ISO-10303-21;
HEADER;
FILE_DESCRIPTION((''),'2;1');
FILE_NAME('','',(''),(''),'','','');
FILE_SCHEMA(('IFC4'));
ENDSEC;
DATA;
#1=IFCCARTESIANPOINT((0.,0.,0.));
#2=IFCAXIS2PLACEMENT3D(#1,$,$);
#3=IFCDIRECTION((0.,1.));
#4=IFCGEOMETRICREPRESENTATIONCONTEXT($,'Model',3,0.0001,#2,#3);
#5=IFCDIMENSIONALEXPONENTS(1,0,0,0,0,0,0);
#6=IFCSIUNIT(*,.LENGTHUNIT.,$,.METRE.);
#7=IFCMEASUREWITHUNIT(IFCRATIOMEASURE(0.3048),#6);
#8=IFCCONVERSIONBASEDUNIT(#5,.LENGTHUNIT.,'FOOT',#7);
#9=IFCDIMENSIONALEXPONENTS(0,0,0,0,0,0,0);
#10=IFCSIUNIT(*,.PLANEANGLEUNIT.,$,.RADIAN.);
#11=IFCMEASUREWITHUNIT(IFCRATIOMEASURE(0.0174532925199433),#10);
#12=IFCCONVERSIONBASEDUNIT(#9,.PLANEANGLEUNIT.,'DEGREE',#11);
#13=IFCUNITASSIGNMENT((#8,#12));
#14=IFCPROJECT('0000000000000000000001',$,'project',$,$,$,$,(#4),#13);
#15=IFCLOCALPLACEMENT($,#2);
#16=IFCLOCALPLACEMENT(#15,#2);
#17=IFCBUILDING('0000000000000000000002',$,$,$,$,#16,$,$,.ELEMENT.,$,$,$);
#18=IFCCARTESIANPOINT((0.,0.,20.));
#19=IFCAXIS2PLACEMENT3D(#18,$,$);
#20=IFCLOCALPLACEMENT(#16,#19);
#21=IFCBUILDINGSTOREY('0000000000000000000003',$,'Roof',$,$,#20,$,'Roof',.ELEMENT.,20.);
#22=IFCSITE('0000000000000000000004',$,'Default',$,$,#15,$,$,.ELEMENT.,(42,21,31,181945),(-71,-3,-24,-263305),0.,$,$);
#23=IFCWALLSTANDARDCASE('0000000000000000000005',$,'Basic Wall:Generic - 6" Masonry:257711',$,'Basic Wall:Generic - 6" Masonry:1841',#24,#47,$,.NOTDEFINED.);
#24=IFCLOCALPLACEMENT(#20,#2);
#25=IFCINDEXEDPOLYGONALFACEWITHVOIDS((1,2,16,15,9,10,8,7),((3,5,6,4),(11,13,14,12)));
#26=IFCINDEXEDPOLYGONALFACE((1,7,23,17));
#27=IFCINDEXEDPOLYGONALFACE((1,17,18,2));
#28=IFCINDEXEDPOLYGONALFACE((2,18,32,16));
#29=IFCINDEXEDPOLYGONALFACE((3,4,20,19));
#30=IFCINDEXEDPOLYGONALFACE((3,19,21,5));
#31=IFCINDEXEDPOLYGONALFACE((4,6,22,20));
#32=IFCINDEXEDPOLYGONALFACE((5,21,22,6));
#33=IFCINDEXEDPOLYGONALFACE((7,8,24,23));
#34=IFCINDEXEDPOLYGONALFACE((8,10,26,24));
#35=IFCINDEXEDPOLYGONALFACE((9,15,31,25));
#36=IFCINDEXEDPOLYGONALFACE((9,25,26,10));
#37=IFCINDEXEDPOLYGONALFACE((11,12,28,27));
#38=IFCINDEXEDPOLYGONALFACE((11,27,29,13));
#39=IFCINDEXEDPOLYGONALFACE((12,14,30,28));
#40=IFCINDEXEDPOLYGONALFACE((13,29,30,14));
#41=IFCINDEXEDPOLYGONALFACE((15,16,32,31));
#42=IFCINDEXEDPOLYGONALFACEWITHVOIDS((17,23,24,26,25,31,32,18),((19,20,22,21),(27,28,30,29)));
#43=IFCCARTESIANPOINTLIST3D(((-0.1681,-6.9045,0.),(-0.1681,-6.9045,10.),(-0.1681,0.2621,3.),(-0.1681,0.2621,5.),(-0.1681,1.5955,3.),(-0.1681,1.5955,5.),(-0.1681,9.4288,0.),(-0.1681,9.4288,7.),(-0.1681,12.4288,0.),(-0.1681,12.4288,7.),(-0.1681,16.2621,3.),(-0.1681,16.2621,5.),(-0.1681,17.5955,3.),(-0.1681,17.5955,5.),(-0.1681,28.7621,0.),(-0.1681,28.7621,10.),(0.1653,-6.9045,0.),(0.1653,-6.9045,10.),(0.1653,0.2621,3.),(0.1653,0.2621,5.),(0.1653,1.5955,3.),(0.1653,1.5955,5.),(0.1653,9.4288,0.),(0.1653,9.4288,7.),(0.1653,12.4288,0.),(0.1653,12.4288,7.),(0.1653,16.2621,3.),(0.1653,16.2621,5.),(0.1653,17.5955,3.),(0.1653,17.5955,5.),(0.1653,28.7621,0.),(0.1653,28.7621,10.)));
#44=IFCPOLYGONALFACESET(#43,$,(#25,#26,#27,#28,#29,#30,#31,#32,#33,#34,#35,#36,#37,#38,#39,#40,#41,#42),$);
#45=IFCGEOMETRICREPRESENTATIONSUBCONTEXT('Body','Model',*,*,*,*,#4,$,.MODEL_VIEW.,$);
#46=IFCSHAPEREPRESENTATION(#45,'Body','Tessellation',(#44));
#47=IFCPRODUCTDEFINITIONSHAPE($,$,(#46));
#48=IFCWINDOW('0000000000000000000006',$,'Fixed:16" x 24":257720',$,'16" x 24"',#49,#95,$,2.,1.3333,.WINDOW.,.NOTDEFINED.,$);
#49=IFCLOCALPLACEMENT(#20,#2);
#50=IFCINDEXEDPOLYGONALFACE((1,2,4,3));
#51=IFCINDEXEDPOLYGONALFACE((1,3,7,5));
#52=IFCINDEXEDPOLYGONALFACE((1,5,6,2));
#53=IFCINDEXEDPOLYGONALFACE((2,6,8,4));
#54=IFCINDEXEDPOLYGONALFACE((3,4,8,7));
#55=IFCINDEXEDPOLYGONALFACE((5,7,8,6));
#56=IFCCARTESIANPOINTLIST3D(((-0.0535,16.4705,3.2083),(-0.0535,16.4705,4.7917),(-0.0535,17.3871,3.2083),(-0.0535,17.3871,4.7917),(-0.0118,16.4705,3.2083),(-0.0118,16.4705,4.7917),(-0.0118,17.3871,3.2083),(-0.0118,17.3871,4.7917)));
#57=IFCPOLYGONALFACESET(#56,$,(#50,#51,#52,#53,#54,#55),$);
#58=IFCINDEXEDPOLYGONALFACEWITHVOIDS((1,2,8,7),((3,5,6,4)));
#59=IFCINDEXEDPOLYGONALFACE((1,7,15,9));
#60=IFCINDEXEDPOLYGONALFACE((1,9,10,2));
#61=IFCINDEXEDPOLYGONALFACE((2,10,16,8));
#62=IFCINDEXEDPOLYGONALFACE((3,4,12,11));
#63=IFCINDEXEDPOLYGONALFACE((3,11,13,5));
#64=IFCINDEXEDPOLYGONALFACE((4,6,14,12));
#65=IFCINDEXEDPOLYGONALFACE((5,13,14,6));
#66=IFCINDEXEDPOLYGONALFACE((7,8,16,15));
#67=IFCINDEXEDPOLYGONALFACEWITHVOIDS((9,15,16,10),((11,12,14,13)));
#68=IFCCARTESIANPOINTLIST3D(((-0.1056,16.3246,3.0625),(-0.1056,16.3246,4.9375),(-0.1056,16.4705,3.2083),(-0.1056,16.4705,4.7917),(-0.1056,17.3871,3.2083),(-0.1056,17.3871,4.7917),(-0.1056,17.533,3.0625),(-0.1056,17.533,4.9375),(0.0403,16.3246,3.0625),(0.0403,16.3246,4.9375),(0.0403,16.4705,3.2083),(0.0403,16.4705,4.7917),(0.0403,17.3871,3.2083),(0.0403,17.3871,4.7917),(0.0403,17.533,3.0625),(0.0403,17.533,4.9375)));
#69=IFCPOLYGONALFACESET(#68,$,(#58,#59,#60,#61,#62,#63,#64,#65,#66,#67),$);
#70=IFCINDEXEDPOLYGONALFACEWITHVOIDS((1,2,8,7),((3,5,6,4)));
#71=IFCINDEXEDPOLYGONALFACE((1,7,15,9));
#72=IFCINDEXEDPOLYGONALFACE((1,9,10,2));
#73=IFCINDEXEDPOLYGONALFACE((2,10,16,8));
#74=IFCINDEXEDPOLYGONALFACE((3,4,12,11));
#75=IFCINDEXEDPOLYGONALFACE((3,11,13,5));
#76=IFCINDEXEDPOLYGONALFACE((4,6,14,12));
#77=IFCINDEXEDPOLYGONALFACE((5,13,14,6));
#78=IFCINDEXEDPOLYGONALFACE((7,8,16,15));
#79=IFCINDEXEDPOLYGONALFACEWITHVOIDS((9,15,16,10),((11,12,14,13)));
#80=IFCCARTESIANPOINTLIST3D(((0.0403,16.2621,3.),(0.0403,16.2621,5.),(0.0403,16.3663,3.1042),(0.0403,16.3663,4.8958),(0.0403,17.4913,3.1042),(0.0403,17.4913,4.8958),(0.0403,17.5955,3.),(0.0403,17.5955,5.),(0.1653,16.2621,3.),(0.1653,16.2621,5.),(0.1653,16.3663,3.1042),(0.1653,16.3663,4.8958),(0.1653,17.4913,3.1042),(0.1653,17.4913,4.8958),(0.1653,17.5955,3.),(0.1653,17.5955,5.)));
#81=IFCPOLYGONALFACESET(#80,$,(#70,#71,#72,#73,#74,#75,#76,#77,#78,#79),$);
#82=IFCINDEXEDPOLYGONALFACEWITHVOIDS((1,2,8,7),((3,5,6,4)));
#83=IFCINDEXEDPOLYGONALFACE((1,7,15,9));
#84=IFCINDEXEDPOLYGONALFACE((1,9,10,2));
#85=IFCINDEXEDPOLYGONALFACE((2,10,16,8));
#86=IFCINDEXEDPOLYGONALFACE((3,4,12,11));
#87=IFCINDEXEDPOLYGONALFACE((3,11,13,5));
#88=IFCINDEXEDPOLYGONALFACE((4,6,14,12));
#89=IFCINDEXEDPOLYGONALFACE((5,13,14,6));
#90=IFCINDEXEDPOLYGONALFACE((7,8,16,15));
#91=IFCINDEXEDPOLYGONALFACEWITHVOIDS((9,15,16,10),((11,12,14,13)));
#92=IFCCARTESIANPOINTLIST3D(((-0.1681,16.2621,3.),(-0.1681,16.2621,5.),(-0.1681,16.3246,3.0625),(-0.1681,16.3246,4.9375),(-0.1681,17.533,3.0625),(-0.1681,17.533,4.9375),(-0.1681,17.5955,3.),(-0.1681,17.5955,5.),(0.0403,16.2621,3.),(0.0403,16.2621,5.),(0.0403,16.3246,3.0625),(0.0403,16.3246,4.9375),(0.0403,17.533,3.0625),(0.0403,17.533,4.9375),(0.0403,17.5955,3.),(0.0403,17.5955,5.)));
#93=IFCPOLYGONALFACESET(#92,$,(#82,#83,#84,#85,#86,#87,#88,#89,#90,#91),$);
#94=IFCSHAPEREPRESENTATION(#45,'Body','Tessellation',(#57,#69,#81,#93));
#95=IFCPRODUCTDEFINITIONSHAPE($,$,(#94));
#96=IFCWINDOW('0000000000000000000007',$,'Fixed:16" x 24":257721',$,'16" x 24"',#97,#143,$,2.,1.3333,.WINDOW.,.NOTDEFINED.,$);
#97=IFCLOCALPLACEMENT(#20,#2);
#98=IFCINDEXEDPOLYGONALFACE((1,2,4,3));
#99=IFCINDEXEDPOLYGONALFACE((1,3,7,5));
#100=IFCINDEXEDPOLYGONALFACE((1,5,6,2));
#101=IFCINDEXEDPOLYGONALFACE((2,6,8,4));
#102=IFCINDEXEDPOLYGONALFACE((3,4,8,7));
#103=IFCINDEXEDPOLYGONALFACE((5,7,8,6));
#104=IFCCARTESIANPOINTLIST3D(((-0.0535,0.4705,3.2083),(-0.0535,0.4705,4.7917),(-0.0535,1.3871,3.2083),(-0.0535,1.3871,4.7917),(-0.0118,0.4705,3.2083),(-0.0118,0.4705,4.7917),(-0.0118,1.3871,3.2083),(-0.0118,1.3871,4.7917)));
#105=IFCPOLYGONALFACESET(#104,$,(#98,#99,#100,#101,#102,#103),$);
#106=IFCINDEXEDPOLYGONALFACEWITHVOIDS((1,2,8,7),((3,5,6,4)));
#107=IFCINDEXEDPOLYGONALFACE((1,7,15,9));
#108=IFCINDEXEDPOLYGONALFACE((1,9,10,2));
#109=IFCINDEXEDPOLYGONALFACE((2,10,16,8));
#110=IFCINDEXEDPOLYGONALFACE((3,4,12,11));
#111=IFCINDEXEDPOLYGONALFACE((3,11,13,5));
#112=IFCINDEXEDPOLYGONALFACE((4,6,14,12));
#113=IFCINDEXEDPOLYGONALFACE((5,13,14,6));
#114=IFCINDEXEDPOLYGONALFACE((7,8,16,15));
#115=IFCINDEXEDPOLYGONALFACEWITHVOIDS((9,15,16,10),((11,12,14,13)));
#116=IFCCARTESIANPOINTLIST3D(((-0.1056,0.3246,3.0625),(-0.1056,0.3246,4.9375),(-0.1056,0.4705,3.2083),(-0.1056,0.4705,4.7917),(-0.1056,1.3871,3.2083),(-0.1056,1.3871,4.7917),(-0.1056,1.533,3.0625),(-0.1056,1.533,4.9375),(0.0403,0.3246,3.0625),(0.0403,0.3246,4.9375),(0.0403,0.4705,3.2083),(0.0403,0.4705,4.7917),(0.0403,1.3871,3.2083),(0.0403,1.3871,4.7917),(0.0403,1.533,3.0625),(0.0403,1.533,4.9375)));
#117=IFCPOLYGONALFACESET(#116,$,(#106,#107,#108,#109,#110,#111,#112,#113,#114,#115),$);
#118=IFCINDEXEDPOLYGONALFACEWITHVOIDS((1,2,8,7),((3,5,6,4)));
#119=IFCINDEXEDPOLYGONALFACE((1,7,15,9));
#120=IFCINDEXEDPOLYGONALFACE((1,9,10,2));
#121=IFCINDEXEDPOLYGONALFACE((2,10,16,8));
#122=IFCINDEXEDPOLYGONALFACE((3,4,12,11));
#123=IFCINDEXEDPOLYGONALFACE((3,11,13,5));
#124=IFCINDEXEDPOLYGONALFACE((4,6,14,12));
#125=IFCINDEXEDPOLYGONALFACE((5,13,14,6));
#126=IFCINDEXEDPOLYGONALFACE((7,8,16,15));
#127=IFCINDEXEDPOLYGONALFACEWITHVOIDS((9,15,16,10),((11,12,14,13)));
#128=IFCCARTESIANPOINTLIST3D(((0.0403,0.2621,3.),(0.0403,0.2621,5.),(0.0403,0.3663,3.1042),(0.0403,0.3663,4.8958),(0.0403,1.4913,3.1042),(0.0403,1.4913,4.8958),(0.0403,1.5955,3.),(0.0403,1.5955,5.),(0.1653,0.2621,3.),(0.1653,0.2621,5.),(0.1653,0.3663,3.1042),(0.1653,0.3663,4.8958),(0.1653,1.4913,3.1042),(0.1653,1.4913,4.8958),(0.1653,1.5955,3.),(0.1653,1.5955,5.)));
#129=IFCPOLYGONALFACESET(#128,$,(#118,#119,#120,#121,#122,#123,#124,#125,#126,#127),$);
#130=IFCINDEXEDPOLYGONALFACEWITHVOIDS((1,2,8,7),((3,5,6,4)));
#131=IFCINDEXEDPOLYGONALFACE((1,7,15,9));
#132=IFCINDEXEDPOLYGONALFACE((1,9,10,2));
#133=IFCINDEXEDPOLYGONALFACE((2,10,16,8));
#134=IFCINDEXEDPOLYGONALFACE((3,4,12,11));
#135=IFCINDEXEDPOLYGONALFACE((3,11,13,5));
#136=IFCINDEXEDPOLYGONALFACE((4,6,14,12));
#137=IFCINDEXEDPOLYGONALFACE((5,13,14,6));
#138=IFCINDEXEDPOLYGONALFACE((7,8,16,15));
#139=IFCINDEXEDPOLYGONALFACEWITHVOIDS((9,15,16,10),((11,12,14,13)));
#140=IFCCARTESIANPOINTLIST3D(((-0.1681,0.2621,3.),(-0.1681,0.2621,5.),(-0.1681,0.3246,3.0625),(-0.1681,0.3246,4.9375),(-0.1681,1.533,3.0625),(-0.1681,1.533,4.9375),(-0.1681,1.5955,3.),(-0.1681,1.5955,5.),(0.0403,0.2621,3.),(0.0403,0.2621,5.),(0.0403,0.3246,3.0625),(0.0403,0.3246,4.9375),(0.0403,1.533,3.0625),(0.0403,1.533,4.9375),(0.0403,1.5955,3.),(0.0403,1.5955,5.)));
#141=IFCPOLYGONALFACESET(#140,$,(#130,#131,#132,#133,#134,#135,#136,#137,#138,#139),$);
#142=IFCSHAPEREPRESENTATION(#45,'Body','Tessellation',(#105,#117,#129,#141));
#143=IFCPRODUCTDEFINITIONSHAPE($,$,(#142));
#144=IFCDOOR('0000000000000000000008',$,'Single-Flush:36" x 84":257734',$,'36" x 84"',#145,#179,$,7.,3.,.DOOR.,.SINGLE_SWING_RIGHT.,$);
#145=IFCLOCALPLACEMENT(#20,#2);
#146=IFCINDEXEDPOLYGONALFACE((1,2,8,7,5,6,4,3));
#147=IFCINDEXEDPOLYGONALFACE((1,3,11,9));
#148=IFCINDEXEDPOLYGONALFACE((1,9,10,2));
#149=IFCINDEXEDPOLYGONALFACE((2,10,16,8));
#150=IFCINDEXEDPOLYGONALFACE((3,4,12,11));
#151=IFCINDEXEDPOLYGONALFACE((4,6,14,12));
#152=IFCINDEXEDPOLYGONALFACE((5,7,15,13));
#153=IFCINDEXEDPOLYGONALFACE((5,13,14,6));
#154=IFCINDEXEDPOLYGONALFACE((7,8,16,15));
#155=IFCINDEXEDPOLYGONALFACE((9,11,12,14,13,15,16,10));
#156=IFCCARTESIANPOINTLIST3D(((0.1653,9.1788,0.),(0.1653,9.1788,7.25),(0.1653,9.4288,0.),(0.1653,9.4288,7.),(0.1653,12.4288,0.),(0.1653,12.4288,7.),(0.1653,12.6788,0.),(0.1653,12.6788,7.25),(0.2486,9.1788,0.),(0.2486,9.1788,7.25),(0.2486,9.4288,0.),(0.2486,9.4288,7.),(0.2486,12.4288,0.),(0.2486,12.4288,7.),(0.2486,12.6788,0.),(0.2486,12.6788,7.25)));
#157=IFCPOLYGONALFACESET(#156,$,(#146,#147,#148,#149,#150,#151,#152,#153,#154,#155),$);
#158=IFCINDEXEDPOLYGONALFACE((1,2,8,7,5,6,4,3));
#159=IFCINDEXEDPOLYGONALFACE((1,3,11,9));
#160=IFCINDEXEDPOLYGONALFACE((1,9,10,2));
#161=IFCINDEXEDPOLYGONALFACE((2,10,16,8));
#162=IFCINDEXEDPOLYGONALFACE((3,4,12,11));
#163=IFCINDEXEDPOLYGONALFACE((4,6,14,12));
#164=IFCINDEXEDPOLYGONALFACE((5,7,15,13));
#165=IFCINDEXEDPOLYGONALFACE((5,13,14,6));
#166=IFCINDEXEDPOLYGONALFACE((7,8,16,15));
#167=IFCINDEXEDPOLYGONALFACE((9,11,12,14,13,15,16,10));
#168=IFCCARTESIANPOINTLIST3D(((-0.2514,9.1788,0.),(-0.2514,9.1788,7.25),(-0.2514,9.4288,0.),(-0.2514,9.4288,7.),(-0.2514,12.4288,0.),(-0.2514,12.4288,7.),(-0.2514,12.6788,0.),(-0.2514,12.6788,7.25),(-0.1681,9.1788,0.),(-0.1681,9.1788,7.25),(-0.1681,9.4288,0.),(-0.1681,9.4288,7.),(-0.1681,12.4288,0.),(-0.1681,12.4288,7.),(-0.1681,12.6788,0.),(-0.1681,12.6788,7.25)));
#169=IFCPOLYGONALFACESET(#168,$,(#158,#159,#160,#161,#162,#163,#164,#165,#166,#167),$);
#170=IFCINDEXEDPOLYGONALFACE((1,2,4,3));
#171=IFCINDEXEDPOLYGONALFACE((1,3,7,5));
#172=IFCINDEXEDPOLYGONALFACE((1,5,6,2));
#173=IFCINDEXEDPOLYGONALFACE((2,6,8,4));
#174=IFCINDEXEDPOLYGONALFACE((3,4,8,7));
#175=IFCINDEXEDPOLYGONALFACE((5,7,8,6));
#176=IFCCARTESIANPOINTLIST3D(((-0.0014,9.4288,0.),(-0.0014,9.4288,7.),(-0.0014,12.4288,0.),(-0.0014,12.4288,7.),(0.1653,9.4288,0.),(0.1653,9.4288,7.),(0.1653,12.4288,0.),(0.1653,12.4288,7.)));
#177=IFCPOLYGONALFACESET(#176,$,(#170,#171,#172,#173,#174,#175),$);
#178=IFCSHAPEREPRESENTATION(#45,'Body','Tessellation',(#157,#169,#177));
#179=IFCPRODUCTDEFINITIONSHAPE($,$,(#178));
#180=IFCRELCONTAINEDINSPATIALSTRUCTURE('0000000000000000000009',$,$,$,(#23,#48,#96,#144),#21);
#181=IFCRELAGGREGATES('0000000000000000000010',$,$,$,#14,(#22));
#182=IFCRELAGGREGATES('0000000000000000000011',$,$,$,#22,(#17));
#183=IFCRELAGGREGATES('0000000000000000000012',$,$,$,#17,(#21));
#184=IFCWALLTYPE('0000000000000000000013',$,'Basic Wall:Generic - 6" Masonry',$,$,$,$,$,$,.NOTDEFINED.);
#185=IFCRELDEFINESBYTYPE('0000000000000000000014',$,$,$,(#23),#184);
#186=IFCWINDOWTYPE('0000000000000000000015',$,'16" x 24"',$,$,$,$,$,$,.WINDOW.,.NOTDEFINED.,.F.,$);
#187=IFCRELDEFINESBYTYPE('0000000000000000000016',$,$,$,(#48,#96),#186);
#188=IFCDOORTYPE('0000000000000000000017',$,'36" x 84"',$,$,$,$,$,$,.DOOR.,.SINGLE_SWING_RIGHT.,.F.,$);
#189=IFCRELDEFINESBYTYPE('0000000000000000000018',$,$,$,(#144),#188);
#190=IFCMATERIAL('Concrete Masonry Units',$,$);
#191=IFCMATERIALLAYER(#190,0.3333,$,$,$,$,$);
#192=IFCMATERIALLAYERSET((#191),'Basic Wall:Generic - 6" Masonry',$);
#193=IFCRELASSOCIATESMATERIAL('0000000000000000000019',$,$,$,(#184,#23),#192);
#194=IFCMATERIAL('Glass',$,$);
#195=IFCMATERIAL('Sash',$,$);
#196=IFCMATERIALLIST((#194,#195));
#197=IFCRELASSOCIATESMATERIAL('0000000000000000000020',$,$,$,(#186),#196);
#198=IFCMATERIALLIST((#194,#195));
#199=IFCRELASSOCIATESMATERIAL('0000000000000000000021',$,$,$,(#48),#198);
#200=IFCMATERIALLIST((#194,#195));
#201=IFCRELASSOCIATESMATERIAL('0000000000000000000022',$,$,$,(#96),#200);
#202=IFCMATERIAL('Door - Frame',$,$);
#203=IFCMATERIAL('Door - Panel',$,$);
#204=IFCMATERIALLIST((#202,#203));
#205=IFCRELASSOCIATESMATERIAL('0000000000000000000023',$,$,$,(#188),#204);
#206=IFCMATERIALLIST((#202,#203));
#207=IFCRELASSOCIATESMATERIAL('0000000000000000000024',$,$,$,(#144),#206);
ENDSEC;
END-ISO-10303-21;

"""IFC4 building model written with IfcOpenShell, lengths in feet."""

from ifc_helpers import new_model, entity, si_unit, converted_unit, direction, frame, frame_2d, origin, origin_2d_with_axis, place, context, subcontext, project, spatial, polyline, rectangle, outline, extrude, source, transform, mapped, material, material_list, layer, layer_set, layer_usage, type_object, type_shapes, element, fill, save


model = new_model("IFC4")

# Units and contexts
model_context = context("Model", 3, precision=0.0001, world=origin(), true_north=direction((0.0, 1.0)))
body_context = subcontext(model_context, "Body", "Model", "MODEL_VIEW")
ifc_project = project(units=[converted_unit("LENGTHUNIT", "FOOT", entity("IfcRatioMeasure", 0.3048), si_unit("LENGTHUNIT", "METRE"), dimensions=[1, 0, 0, 0, 0, 0, 0]), converted_unit("PLANEANGLEUNIT", "DEGREE", entity("IfcRatioMeasure", 0.0174532925199433), si_unit("PLANEANGLEUNIT", "RADIAN"), dimensions=[0, 0, 0, 0, 0, 0, 0])], contexts=[model_context])

# Site, building, storey
site_placement = place(None, origin())
site = spatial("IfcSite", under=ifc_project, at=site_placement, Name="Default", CompositionType="ELEMENT", RefLatitude=(42, 21, 31, 181945), RefLongitude=(-71, -3, -24, -263305), RefElevation=0.0)
building_placement = place(site_placement, origin())
building = spatial("IfcBuilding", under=site, at=building_placement, CompositionType="ELEMENT")
storey_placement = place(building_placement, frame((0.0, 0.0, 20.0)))
storey = spatial("IfcBuildingStorey", under=building, at=storey_placement, Name="Roof", LongName="Roof", CompositionType="ELEMENT", Elevation=20.0)

# Shared definitions
wall_placement = place(storey_placement, frame((-0.0014, -6.9045, 0.0), z_axis=(0.0, 0.0, 1.0), x_axis=(0.0, 1.0, 0.0)))

# Wall, openings, windows, door
ifc_material_1 = material(Name="Concrete Masonry Units")
ifc_layer = layer(ifc_material_1, 0.3333)
ifc_layer_set = layer_set([ifc_layer], Name="Basic Wall:Generic - 6\" Masonry")
ifc_layer_usage = layer_usage(ifc_layer_set, "AXIS2", "NEGATIVE", 0.1667)
wall_type = type_object("IfcWallType", Name="Basic Wall:Generic - 6\" Masonry", PredefinedType="NOTDEFINED", material=ifc_layer_set)
wall = element("IfcWallStandardCase", 1, at=wall_placement, inside=storey, type_object=wall_type, material=ifc_layer_usage, Name="Basic Wall:Generic - 6\" Masonry:257711", ObjectType="Basic Wall:Generic - 6\" Masonry:1841", PredefinedType="NOTDEFINED", context=body_context, shape_type="SweptSolid", body=[
    extrude(rectangle(XDim=35.6667, YDim=0.3333, at=frame_2d((17.8333, 0.0), x_axis=(-1.0, 0.0))), origin(), (0.0, 0.0, 1.0), 10.0),
])
opening_1_placement = place(wall_placement, frame((19.3333, 0.1667, 0.0)))
opening_1 = element("IfcOpeningElement", 2, at=opening_1_placement, cuts=wall, ObjectType="Opening", PredefinedType="OPENING", context=body_context, shape_type="SweptSolid", body=[
    extrude(rectangle(XDim=3.0, YDim=7.0, at=frame_2d((3.5, 1.5), x_axis=(0.0, 1.0))), frame((0.0, 0.0, 0.0), z_axis=(0.0, -1.0, 0.0), x_axis=(0.0, 0.0, 1.0)), (0.0, 0.0, 1.0), 0.3333),
])
opening_2_placement = place(wall_placement, frame((23.1667, -0.1667, 3.0)))
opening_2 = element("IfcOpeningElement", 3, at=opening_2_placement, cuts=wall, ObjectType="Opening", PredefinedType="OPENING", context=body_context, shape_type="SweptSolid", body=[
    extrude(rectangle(XDim=2.0, YDim=1.3333, at=frame_2d((1.0, 0.6667), x_axis=(-1.0, 0.0))), frame((0.0, 0.0, 0.0), z_axis=(0.0, 1.0, 0.0), x_axis=(0.0, 0.0, 1.0)), (0.0, 0.0, 1.0), 0.3333),
])
opening_3_placement = place(wall_placement, frame((7.1667, -0.1667, 3.0)))
opening_3 = element("IfcOpeningElement", 4, at=opening_3_placement, cuts=wall, ObjectType="Opening", PredefinedType="OPENING", context=body_context, shape_type="SweptSolid", body=[
    extrude(rectangle(XDim=2.0, YDim=1.3333, at=frame_2d((1.0, 0.6667), x_axis=(-1.0, 0.0))), frame((0.0, 0.0, 0.0), z_axis=(0.0, 1.0, 0.0), x_axis=(0.0, 0.0, 1.0)), (0.0, 0.0, 1.0), 0.3333),
])
ifc_material_2 = material(Name="Glass")
ifc_material_3 = material(Name="Sash")
ifc_material_list_1 = material_list([ifc_material_2, ifc_material_3])
ifc_material_list_2 = material_list([ifc_material_2, ifc_material_3])
window_type = type_object("IfcWindowType", Name="16\" x 24\"", ParameterTakesPrecedence=False, PartitioningType="NOTDEFINED", PredefinedType="WINDOW", material=ifc_material_list_2)
shared_shape_1 = source(origin(), body_context, "Body", "SweptSolid", [
    extrude(rectangle(XDim=0.0417, YDim=0.9167, at=origin_2d_with_axis()), frame((0.6667, 0.1979, 0.2083), z_axis=(0.0, 0.0, 1.0), x_axis=(0.0, 1.0, 0.0)), (0.0, 0.0, 1.0), 1.5833),
    extrude(outline(polyline([(-0.6042, -0.9375), (0.6042, -0.9375), (0.6042, 0.9375), (-0.6042, 0.9375), (-0.6042, -0.9375)]), holes=[polyline([(-0.4583, -0.7917), (-0.4583, 0.7917), (0.4583, 0.7917), (0.4583, -0.7917), (-0.4583, -0.7917)])]), frame((0.6667, 0.125, 1.0), z_axis=(0.0, 1.0, 0.0), x_axis=(1.0, 0.0, 0.0)), (0.0, 0.0, 1.0), 0.1458),
    extrude(outline(polyline([(-0.6667, -1.0), (0.6667, -1.0), (0.6667, 1.0), (-0.6667, 1.0), (-0.6667, -1.0)]), holes=[polyline([(-0.5625, -0.8958), (-0.5625, 0.8958), (0.5625, 0.8958), (0.5625, -0.8958), (-0.5625, -0.8958)])]), frame((0.6667, 0.0, 1.0), z_axis=(0.0, 1.0, 0.0), x_axis=(1.0, 0.0, 0.0)), (0.0, 0.0, 1.0), 0.125),
    extrude(outline(polyline([(-1.0, -0.6667), (1.0, -0.6667), (1.0, 0.6667), (-1.0, 0.6667), (-1.0, -0.6667)]), holes=[polyline([(-0.9375, -0.6042), (-0.9375, 0.6042), (0.9375, 0.6042), (0.9375, -0.6042), (-0.9375, -0.6042)])]), frame((0.6667, 0.125, 1.0), z_axis=(0.0, 1.0, 0.0), x_axis=(0.0, 0.0, -1.0)), (0.0, 0.0, 1.0), 0.2083),
])
type_shapes(window_type, [shared_shape_1])
window_1_placement = place(opening_2_placement, origin())
window_1 = element("IfcWindow", 5, at=window_1_placement, inside=storey, type_object=window_type, material=ifc_material_list_1, Name="Fixed:16\" x 24\":257720", ObjectType="16\" x 24\"", OverallHeight=2.0, OverallWidth=1.3333, PartitioningType="NOTDEFINED", PredefinedType="WINDOW", context=body_context, shape_type="MappedRepresentation", body=[
    mapped(shared_shape_1, transform((0.0, 0.0, 0.0), scale=1.0)),
])
fill(opening_2, window_1)
ifc_material_list_3 = material_list([ifc_material_2, ifc_material_3])
window_2_placement = place(opening_3_placement, origin())
window_2 = element("IfcWindow", 6, at=window_2_placement, inside=storey, type_object=window_type, material=ifc_material_list_3, Name="Fixed:16\" x 24\":257721", ObjectType="16\" x 24\"", OverallHeight=2.0, OverallWidth=1.3333, PartitioningType="NOTDEFINED", PredefinedType="WINDOW", context=body_context, shape_type="MappedRepresentation", body=[
    mapped(shared_shape_1, transform((0.0, 0.0, 0.0), scale=1.0)),
])
fill(opening_3, window_2)
ifc_material_4 = material(Name="Door - Frame")
ifc_material_5 = material(Name="Door - Panel")
ifc_material_list_4 = material_list([ifc_material_4, ifc_material_5])
ifc_material_list_5 = material_list([ifc_material_4, ifc_material_5])
door_type = type_object("IfcDoorType", Name="36\" x 84\"", OperationType="SINGLE_SWING_RIGHT", ParameterTakesPrecedence=False, PredefinedType="DOOR", material=ifc_material_list_5)
shared_shape_2 = source(origin(), body_context, "Body", "SweptSolid", [
    extrude(outline(polyline([(-1.75, -3.6875), (1.75, -3.6875), (1.75, 3.5625), (1.5, 3.5625), (1.5, -3.4375), (-1.5, -3.4375), (-1.5, 3.5625), (-1.75, 3.5625), (-1.75, -3.6875)])), frame((1.5, 0.3333, 3.5625), z_axis=(0.0, 1.0, 0.0), x_axis=(1.0, 0.0, 0.0)), (0.0, 0.0, 1.0), 0.0833),
    extrude(outline(polyline([(-3.6875, -1.75), (3.5625, -1.75), (3.5625, -1.5), (-3.4375, -1.5), (-3.4375, 1.5), (3.5625, 1.5), (3.5625, 1.75), (-3.6875, 1.75), (-3.6875, -1.75)])), frame((1.5, -0.0833, 3.5625), z_axis=(0.0, 1.0, 0.0), x_axis=(0.0, 0.0, -1.0)), (0.0, 0.0, 1.0), 0.0833),
    extrude(rectangle(XDim=0.1667, YDim=3.0, at=frame_2d((0.0, 0.0), x_axis=(1.0, 0.0))), frame((1.5, 0.25, 0.0), z_axis=(0.0, 0.0, 1.0), x_axis=(0.0, 1.0, 0.0)), (0.0, 0.0, 1.0), 7.0),
])
type_shapes(door_type, [shared_shape_2])
door_placement = place(opening_1_placement, frame((0.0, 0.0, 0.0), z_axis=(0.0, 0.0, 1.0), x_axis=(-1.0, 0.0, 0.0)))
door = element("IfcDoor", 7, at=door_placement, inside=storey, type_object=door_type, material=ifc_material_list_4, Name="Single-Flush:36\" x 84\":257734", ObjectType="36\" x 84\"", OperationType="SINGLE_SWING_RIGHT", OverallHeight=7.0, OverallWidth=3.0, PredefinedType="DOOR", context=body_context, shape_type="MappedRepresentation", body=[
    mapped(shared_shape_2, transform((0.0, 0.0, 0.0), scale=1.0)),
])
fill(opening_1, door)

save(model, "model.ifc")
